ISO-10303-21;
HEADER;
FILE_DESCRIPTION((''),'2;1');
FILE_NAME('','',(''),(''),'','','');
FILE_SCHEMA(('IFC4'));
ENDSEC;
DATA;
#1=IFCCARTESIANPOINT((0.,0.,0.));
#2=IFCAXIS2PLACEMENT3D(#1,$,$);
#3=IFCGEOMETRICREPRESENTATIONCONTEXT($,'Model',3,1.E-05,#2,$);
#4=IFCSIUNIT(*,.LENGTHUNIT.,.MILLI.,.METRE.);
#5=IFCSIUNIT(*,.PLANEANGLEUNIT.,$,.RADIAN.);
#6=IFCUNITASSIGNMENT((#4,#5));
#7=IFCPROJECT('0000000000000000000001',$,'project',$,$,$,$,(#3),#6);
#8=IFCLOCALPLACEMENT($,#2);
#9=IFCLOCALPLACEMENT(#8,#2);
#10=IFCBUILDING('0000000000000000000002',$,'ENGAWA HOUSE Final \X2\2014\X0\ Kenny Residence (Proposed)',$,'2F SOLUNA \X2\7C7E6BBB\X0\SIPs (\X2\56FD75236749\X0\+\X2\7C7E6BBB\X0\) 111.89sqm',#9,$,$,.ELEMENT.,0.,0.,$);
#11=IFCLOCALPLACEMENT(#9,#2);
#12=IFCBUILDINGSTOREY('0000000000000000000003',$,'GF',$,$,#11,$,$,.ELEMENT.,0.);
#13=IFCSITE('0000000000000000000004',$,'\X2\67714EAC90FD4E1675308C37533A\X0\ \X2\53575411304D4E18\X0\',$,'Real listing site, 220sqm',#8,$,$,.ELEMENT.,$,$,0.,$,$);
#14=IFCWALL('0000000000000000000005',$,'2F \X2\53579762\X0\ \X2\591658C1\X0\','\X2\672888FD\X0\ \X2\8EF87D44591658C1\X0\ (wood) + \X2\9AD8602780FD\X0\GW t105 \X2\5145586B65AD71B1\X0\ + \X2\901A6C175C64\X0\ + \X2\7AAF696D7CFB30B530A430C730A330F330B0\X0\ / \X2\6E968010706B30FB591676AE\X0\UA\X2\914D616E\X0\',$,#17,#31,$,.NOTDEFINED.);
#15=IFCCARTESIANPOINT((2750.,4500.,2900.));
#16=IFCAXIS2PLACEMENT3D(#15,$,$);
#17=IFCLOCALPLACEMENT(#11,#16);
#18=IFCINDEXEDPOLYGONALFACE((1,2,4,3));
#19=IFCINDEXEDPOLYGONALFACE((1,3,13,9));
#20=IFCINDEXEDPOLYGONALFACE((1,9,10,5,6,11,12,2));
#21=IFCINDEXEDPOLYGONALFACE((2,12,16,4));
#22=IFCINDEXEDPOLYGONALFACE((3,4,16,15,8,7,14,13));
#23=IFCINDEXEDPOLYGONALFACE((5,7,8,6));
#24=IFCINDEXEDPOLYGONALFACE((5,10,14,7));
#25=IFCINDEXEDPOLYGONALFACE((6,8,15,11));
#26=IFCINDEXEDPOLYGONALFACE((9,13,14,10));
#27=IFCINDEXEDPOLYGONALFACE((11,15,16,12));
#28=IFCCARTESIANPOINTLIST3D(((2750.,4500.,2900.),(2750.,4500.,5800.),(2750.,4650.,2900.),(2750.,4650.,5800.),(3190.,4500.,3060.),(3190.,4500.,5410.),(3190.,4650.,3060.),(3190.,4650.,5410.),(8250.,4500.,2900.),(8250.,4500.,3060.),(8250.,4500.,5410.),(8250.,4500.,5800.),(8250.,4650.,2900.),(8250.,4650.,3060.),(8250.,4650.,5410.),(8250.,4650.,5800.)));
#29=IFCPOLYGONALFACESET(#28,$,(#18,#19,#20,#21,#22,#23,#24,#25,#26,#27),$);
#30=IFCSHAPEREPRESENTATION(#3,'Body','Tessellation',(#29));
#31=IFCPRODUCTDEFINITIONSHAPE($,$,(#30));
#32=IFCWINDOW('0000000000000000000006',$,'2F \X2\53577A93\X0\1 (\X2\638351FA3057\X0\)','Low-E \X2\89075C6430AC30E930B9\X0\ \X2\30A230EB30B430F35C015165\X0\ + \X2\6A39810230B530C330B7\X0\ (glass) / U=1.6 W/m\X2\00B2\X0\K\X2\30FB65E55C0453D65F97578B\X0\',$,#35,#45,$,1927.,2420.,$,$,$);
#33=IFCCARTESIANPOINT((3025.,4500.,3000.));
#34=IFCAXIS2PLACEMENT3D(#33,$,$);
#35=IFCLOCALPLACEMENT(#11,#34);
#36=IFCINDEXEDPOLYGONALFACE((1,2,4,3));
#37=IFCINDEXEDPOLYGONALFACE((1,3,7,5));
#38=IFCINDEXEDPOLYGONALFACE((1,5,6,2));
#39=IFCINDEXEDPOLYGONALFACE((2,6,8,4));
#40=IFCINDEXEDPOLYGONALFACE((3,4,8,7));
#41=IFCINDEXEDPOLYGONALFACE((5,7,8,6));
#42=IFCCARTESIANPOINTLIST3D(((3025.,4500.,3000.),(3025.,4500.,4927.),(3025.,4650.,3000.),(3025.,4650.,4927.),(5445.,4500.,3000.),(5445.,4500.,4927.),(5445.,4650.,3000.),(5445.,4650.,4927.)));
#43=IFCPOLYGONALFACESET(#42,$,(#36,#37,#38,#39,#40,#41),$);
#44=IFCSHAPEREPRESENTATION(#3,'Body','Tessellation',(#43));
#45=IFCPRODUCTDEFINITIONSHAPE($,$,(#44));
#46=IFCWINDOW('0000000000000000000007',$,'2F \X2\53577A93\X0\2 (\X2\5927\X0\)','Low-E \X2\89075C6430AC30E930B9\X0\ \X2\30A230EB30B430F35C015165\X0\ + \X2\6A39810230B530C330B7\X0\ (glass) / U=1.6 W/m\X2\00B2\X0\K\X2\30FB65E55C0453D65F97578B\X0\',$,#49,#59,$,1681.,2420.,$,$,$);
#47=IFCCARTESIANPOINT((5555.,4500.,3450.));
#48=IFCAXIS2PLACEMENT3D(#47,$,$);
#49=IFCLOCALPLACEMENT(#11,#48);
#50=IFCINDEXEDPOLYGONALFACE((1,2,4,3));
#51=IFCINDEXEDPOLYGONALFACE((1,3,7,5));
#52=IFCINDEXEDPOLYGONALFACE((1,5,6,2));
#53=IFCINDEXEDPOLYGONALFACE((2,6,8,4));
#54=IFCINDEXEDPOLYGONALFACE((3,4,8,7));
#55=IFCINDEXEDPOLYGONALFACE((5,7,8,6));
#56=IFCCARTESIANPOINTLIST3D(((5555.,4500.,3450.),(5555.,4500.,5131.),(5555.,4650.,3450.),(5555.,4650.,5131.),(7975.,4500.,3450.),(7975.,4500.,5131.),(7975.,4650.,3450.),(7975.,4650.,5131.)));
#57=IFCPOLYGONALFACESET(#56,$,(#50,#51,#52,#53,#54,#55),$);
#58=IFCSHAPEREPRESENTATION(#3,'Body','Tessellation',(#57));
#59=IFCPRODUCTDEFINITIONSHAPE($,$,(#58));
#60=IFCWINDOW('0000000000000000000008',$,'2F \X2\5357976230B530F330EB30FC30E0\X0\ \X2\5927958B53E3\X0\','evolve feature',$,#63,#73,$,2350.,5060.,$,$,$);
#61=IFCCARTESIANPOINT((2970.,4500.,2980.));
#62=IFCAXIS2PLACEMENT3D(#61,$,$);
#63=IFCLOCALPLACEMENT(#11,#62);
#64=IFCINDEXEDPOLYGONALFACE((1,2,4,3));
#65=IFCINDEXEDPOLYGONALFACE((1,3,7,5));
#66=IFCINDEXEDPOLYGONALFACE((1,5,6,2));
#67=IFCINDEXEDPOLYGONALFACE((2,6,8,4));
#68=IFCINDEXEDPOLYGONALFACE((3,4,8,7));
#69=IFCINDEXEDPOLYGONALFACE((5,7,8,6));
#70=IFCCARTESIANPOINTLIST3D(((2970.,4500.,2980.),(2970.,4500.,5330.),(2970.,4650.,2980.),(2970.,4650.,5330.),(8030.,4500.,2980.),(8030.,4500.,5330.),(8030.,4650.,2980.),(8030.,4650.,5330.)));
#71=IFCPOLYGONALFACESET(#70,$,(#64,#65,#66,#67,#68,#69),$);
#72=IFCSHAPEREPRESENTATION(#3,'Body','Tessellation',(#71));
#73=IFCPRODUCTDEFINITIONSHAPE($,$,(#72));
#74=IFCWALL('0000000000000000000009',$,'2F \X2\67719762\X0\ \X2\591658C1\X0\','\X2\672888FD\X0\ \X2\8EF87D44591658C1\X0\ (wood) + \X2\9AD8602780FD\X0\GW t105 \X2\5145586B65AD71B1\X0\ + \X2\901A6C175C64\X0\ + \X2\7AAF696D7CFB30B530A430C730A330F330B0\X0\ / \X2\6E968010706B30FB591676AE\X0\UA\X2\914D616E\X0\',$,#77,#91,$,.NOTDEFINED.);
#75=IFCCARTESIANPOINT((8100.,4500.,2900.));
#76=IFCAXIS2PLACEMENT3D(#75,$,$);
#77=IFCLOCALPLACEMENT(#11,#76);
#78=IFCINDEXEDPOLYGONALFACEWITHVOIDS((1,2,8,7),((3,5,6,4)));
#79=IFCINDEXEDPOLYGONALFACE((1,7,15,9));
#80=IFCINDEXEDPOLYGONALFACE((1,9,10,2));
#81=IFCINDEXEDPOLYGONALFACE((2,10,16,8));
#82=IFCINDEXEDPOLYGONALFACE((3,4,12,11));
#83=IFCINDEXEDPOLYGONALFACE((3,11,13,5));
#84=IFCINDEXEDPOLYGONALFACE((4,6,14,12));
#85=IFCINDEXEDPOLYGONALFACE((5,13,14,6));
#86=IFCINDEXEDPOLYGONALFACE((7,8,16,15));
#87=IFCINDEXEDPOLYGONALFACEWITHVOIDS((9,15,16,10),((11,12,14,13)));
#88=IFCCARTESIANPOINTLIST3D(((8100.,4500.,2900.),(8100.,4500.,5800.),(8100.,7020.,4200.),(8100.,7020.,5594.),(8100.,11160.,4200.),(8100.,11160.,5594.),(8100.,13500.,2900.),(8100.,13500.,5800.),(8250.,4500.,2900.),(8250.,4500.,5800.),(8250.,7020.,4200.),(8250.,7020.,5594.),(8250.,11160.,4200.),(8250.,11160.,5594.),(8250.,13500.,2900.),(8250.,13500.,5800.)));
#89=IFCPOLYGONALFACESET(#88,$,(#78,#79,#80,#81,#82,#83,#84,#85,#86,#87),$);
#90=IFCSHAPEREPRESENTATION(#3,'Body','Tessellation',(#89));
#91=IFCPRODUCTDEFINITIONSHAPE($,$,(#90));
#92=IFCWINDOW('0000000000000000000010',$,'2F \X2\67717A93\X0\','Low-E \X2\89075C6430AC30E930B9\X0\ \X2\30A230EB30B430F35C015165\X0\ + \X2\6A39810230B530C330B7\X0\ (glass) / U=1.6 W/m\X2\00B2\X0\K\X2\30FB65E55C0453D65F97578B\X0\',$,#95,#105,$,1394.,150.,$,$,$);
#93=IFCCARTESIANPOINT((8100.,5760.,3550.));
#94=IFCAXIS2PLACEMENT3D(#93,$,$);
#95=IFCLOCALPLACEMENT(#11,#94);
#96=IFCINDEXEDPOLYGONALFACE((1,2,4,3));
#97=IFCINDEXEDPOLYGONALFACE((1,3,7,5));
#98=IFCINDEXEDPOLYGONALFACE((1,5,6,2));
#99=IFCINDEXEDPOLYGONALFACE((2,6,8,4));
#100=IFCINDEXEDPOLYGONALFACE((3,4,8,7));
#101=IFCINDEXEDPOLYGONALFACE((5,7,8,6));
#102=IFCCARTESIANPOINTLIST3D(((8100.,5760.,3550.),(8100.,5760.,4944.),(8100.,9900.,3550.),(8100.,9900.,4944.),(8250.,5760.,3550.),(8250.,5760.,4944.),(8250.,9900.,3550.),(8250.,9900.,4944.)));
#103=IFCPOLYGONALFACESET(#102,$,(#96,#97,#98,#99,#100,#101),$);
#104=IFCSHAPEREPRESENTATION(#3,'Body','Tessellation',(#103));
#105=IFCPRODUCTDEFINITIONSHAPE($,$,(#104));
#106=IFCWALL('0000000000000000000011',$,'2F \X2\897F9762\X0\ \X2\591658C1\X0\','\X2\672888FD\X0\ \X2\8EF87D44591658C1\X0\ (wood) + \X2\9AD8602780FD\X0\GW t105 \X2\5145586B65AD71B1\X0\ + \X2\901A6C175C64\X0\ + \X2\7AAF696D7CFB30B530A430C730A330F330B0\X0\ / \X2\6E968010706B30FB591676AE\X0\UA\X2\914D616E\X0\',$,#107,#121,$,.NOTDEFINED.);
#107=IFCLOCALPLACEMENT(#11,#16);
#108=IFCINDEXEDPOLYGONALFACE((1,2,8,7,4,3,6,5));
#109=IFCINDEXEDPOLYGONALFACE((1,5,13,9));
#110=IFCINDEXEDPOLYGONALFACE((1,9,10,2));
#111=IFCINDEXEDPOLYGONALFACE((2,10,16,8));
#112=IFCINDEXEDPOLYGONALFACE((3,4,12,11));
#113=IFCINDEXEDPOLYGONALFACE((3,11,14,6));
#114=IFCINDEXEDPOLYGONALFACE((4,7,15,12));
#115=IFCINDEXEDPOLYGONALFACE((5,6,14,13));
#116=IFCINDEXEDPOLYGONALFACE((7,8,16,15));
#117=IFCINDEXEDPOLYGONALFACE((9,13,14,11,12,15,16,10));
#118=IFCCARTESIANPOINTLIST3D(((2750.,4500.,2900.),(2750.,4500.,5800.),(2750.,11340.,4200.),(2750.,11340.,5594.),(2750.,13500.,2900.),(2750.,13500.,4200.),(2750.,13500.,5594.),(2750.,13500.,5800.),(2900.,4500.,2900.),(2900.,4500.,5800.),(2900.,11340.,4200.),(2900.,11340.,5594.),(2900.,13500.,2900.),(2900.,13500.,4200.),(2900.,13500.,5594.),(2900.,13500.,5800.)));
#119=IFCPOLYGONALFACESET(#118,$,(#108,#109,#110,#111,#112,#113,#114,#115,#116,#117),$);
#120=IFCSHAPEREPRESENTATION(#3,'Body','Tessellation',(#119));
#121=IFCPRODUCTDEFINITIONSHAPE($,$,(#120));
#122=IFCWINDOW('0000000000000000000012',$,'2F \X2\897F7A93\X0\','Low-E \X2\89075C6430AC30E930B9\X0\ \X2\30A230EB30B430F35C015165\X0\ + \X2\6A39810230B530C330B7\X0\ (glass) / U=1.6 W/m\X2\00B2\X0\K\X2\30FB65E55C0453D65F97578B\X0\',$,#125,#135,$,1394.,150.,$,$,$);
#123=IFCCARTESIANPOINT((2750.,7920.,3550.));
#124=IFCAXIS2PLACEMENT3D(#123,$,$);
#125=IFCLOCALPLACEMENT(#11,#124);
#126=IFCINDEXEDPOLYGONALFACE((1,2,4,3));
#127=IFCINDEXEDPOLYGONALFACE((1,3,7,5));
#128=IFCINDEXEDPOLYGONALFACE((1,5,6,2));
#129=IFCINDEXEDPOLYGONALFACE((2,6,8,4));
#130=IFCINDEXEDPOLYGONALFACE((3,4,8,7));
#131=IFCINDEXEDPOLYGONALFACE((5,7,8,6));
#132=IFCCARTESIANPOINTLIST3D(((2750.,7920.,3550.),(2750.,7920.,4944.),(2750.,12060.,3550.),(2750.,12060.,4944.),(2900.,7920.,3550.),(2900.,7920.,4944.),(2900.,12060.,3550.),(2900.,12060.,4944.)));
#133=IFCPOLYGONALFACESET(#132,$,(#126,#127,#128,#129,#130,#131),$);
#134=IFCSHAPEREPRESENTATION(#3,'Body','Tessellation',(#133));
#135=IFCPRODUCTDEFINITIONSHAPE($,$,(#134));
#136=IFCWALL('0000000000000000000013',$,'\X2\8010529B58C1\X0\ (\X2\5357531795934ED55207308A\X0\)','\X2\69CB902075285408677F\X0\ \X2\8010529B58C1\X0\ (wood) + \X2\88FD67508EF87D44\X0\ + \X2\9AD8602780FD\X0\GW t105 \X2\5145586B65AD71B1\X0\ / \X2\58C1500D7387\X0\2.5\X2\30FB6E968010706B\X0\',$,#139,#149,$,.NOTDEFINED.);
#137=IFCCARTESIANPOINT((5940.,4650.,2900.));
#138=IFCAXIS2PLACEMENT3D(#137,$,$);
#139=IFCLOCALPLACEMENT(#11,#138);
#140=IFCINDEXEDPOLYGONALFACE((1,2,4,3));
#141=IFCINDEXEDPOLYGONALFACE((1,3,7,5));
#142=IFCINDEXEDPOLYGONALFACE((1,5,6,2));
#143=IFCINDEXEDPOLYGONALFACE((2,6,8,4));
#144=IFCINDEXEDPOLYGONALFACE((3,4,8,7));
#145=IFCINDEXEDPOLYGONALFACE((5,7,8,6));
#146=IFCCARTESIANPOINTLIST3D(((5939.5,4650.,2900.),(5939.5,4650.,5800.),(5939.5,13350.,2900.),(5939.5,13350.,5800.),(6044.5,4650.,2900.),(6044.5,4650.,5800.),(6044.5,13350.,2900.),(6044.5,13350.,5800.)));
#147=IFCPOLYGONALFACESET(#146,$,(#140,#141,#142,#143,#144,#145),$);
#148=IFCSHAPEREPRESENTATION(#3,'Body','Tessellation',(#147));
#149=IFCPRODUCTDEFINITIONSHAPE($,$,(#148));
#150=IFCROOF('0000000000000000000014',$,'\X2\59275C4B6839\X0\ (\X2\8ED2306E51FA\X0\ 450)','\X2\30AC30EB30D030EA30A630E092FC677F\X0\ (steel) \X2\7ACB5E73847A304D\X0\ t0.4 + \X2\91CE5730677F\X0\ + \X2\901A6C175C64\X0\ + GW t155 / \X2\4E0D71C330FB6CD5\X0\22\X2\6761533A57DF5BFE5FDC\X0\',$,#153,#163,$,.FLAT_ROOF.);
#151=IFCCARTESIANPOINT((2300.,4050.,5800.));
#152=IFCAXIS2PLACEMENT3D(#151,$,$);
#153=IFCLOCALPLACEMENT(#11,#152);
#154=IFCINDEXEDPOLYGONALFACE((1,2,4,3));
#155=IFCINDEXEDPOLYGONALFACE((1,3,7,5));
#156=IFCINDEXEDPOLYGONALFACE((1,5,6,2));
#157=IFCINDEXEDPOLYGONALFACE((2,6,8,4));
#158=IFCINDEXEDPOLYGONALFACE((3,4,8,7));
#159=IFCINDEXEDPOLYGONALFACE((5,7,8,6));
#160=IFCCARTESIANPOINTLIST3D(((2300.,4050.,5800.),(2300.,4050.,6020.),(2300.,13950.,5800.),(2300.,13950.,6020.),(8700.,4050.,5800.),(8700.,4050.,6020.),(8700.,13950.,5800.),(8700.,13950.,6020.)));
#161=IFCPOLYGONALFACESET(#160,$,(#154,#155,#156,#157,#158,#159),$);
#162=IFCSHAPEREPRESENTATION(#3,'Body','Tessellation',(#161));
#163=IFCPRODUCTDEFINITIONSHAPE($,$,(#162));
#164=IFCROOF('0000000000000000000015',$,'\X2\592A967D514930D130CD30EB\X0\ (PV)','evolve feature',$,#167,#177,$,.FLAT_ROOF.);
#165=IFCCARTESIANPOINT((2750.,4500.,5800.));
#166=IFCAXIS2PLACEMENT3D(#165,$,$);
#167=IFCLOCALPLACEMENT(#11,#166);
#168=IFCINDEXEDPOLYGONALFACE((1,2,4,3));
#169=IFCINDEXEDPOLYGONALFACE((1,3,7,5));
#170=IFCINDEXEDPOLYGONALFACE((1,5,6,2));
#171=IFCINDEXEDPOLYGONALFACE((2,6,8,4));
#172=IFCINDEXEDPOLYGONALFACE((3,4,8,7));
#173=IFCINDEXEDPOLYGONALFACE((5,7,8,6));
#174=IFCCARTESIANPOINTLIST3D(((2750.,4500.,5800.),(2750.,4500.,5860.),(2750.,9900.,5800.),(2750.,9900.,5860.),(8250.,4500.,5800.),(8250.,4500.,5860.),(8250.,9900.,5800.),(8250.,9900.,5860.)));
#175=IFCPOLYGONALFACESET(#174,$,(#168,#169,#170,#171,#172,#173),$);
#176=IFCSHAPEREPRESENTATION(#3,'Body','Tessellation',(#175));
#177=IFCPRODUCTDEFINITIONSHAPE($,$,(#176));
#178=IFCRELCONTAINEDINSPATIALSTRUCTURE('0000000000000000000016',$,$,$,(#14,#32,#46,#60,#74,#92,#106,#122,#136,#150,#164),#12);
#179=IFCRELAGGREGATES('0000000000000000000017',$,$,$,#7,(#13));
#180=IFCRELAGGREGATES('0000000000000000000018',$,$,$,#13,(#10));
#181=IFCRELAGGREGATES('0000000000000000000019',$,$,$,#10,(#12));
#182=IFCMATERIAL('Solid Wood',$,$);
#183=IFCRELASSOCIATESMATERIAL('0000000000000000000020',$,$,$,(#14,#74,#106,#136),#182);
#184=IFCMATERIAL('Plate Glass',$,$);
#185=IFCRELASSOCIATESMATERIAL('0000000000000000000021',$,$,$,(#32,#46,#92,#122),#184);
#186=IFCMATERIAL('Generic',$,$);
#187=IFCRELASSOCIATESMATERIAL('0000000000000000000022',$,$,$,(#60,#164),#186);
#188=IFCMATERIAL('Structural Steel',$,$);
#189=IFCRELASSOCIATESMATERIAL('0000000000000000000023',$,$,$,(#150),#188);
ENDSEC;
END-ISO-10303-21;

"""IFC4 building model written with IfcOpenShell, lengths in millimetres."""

from ifc_helpers import new_model, si_unit, frame, frame_2d, origin, place, context, project, spatial, rectangle, extrude, material, element, fill, save


model = new_model("IFC4")

# Units and contexts
model_context = context("Model", 3, precision=1e-05, world=origin())
ifc_project = project(units=[si_unit("LENGTHUNIT", "METRE", prefix="MILLI"), si_unit("PLANEANGLEUNIT", "RADIAN")], contexts=[model_context])

# Site, building, storey
site_placement = place(None, origin())
site = spatial("IfcSite", under=ifc_project, at=site_placement, Name="東京都世田谷区 南向き丘", ObjectType="Real listing site, 220sqm", CompositionType="ELEMENT", RefElevation=0.0)
building_placement = place(site_placement, origin())
building = spatial("IfcBuilding", under=site, at=building_placement, Name="ENGAWA HOUSE Final — Kenny Residence (Proposed)", ObjectType="2F SOLUNA 籾殻SIPs (国産杉+籾殻) 111.89sqm", CompositionType="ELEMENT", ElevationOfRefHeight=0.0, ElevationOfTerrain=0.0)
storey_placement = place(building_placement, origin())
storey = spatial("IfcBuildingStorey", under=building, at=storey_placement, Name="GF", CompositionType="ELEMENT", Elevation=0.0)

# Shared definitions
ifc_material_1 = material(Name="Solid Wood")

# Wall, openings, windows
wall_1_placement = place(storey_placement, frame((2750.0, 4500.0, 2900.0)))
wall_1 = element("IfcWall", 1, at=wall_1_placement, inside=storey, material=ifc_material_1, Name="2F 南面 外壁", Description="木製 軸組外壁 (wood) + 高性能GW t105 充填断熱 + 通気層 + 窯業系サイディング / 準耐火・外皮UA配慮", PredefinedType="NOTDEFINED", context=model_context, shape_type="SweptSolid", body=[
    extrude(rectangle(XDim=5500.0, YDim=150.0, at=frame_2d((2750.0, 75.0))), frame((2750.0, 4500.0, 2900.0)), (0.0, 0.0, 1.0), 2900.0),
])
opening_1_placement = place(storey_placement, frame((3025.0, 4500.0, 3000.0)))
opening_1 = element("IfcOpeningElement", 2, at=opening_1_placement, cuts=wall_1, PredefinedType="NOTDEFINED", context=model_context, shape_type="SweptSolid", body=[
    extrude(rectangle(XDim=2420.0, YDim=150.0, at=frame_2d((1210.0, 75.0))), frame((3025.0, 4500.0, 3000.0)), (0.0, 0.0, 1.0), 1927.0),
])
opening_2_placement = place(storey_placement, frame((5555.0, 4500.0, 3450.0)))
opening_2 = element("IfcOpeningElement", 3, at=opening_2_placement, cuts=wall_1, PredefinedType="NOTDEFINED", context=model_context, shape_type="SweptSolid", body=[
    extrude(rectangle(XDim=2420.0, YDim=150.0, at=frame_2d((1210.0, 75.0))), frame((5555.0, 4500.0, 3450.0)), (0.0, 0.0, 1.0), 1681.0),
])
opening_3_placement = place(storey_placement, frame((2970.0, 4500.0, 2980.0)))
opening_3 = element("IfcOpeningElement", 4, at=opening_3_placement, cuts=wall_1, PredefinedType="NOTDEFINED", context=model_context, shape_type="SweptSolid", body=[
    extrude(rectangle(XDim=5060.0, YDim=150.0, at=frame_2d((2530.0, 75.0))), frame((2970.0, 4500.0, 2980.0)), (0.0, 0.0, 1.0), 2350.0),
])
ifc_material_2 = material(Name="Plate Glass")
window_1_placement = place(storey_placement, frame((3025.0, 4500.0, 3000.0)))
window_1 = element("IfcWindow", 5, at=window_1_placement, inside=storey, material=ifc_material_2, Name="2F 南窓1 (掃出し)", Description="Low-E 複層ガラス アルゴン封入 + 樹脂サッシ (glass) / U=1.6 W/m²K・日射取得型", OverallHeight=1927.0, OverallWidth=2420.0, context=model_context, shape_type="SweptSolid", body=[
    extrude(rectangle(XDim=2420.0, YDim=150.0, at=frame_2d((1210.0, 75.0))), frame((3025.0, 4500.0, 3000.0)), (0.0, 0.0, 1.0), 1927.0),
])
fill(opening_1, window_1)
window_2_placement = place(storey_placement, frame((5555.0, 4500.0, 3450.0)))
window_2 = element("IfcWindow", 6, at=window_2_placement, inside=storey, material=ifc_material_2, Name="2F 南窓2 (大)", Description="Low-E 複層ガラス アルゴン封入 + 樹脂サッシ (glass) / U=1.6 W/m²K・日射取得型", OverallHeight=1681.0, OverallWidth=2420.0, context=model_context, shape_type="SweptSolid", body=[
    extrude(rectangle(XDim=2420.0, YDim=150.0, at=frame_2d((1210.0, 75.0))), frame((5555.0, 4500.0, 3450.0)), (0.0, 0.0, 1.0), 1681.0),
])
fill(opening_2, window_2)
ifc_material_3 = material(Name="Generic")
window_3_placement = place(storey_placement, frame((2970.0, 4500.0, 2980.0)))
window_3 = element("IfcWindow", 7, at=window_3_placement, inside=storey, material=ifc_material_3, Name="2F 南面サンルーム 大開口", Description="evolve feature", OverallHeight=2350.0, OverallWidth=5060.0, context=model_context, shape_type="SweptSolid", body=[
    extrude(rectangle(XDim=5060.0, YDim=150.0, at=frame_2d((2530.0, 75.0))), frame((2970.0, 4500.0, 2980.0)), (0.0, 0.0, 1.0), 2350.0),
])
fill(opening_3, window_3)

# Walls, openings, windows
wall_2_placement = place(storey_placement, frame((8100.0, 4500.0, 2900.0)))
wall_2 = element("IfcWall", 8, at=wall_2_placement, inside=storey, material=ifc_material_1, Name="2F 東面 外壁", Description="木製 軸組外壁 (wood) + 高性能GW t105 充填断熱 + 通気層 + 窯業系サイディング / 準耐火・外皮UA配慮", PredefinedType="NOTDEFINED", context=model_context, shape_type="SweptSolid", body=[
    extrude(rectangle(XDim=150.0, YDim=9000.0, at=frame_2d((75.0, 4500.0))), frame((8100.0, 4500.0, 2900.0)), (0.0, 0.0, 1.0), 2900.0),
])
opening_4_placement = place(storey_placement, frame((8100.0, 5760.0, 3550.0)))
opening_4 = element("IfcOpeningElement", 9, at=opening_4_placement, cuts=wall_2, PredefinedType="NOTDEFINED", context=model_context, shape_type="SweptSolid", body=[
    extrude(rectangle(XDim=150.0, YDim=4140.0, at=frame_2d((75.0, 2070.0))), frame((8100.0, 5760.0, 3550.0)), (0.0, 0.0, 1.0), 1394.0),
])
window_4_placement = place(storey_placement, frame((8100.0, 5760.0, 3550.0)))
window_4 = element("IfcWindow", 10, at=window_4_placement, inside=storey, material=ifc_material_2, Name="2F 東窓", Description="Low-E 複層ガラス アルゴン封入 + 樹脂サッシ (glass) / U=1.6 W/m²K・日射取得型", OverallHeight=1394.0, OverallWidth=150.0, context=model_context, shape_type="SweptSolid", body=[
    extrude(rectangle(XDim=150.0, YDim=4140.0, at=frame_2d((75.0, 2070.0))), frame((8100.0, 5760.0, 3550.0)), (0.0, 0.0, 1.0), 1394.0),
])
fill(opening_4, window_4)
wall_3_placement = place(storey_placement, frame((2750.0, 4500.0, 2900.0)))
wall_3 = element("IfcWall", 11, at=wall_3_placement, inside=storey, material=ifc_material_1, Name="2F 西面 外壁", Description="木製 軸組外壁 (wood) + 高性能GW t105 充填断熱 + 通気層 + 窯業系サイディング / 準耐火・外皮UA配慮", PredefinedType="NOTDEFINED", context=model_context, shape_type="SweptSolid", body=[
    extrude(rectangle(XDim=150.0, YDim=9000.0, at=frame_2d((75.0, 4500.0))), frame((2750.0, 4500.0, 2900.0)), (0.0, 0.0, 1.0), 2900.0),
])
opening_5_placement = place(storey_placement, frame((2750.0, 7920.0, 3550.0)))
opening_5 = element("IfcOpeningElement", 12, at=opening_5_placement, cuts=wall_3, PredefinedType="NOTDEFINED", context=model_context, shape_type="SweptSolid", body=[
    extrude(rectangle(XDim=150.0, YDim=4140.0, at=frame_2d((75.0, 2070.0))), frame((2750.0, 7920.0, 3550.0)), (0.0, 0.0, 1.0), 1394.0),
])
window_5_placement = place(storey_placement, frame((2750.0, 7920.0, 3550.0)))
window_5 = element("IfcWindow", 13, at=window_5_placement, inside=storey, material=ifc_material_2, Name="2F 西窓", Description="Low-E 複層ガラス アルゴン封入 + 樹脂サッシ (glass) / U=1.6 W/m²K・日射取得型", OverallHeight=1394.0, OverallWidth=150.0, context=model_context, shape_type="SweptSolid", body=[
    extrude(rectangle(XDim=150.0, YDim=4140.0, at=frame_2d((75.0, 2070.0))), frame((2750.0, 7920.0, 3550.0)), (0.0, 0.0, 1.0), 1394.0),
])
fill(opening_5, window_5)

# Wall
wall_4_placement = place(storey_placement, frame((5940.0, 4650.0, 2900.0)))
element("IfcWall", 14, at=wall_4_placement, inside=storey, material=ifc_material_1, Name="耐力壁 (南北間仕切り)", Description="構造用合板 耐力壁 (wood) + 製材軸組 + 高性能GW t105 充填断熱 / 壁倍率2.5・準耐火", PredefinedType="NOTDEFINED", context=model_context, shape_type="SweptSolid", body=[
    extrude(rectangle(XDim=105.0, YDim=8700.0, at=frame_2d((52.0, 4350.0))), frame((5940.0, 4650.0, 2900.0)), (0.0, 0.0, 1.0), 2900.0),
])

# Roofs
ifc_material_4 = material(Name="Structural Steel")
roof_1_placement = place(storey_placement, frame((2300.0, 4050.0, 5800.0)))
element("IfcRoof", 15, at=roof_1_placement, inside=storey, material=ifc_material_4, Name="大屋根 (軒の出 450)", Description="ガルバリウム鋼板 (steel) 立平葺き t0.4 + 野地板 + 通気層 + GW t155 / 不燃・法22条区域対応", PredefinedType="FLAT_ROOF", context=model_context, shape_type="SweptSolid", body=[
    extrude(rectangle(XDim=6400.0, YDim=9900.0, at=frame_2d((3200.0, 4950.0))), frame((2300.0, 4050.0, 5800.0)), (0.0, 0.0, 1.0), 220.0),
])
roof_2_placement = place(storey_placement, frame((2750.0, 4500.0, 5800.0)))
element("IfcRoof", 16, at=roof_2_placement, inside=storey, material=ifc_material_3, Name="太陽光パネル (PV)", Description="evolve feature", PredefinedType="FLAT_ROOF", context=model_context, shape_type="SweptSolid", body=[
    extrude(rectangle(XDim=5500.0, YDim=5400.0, at=frame_2d((2750.0, 2700.0))), frame((2750.0, 4500.0, 5800.0)), (0.0, 0.0, 1.0), 60.0),
])

save(model, "model.ifc")
